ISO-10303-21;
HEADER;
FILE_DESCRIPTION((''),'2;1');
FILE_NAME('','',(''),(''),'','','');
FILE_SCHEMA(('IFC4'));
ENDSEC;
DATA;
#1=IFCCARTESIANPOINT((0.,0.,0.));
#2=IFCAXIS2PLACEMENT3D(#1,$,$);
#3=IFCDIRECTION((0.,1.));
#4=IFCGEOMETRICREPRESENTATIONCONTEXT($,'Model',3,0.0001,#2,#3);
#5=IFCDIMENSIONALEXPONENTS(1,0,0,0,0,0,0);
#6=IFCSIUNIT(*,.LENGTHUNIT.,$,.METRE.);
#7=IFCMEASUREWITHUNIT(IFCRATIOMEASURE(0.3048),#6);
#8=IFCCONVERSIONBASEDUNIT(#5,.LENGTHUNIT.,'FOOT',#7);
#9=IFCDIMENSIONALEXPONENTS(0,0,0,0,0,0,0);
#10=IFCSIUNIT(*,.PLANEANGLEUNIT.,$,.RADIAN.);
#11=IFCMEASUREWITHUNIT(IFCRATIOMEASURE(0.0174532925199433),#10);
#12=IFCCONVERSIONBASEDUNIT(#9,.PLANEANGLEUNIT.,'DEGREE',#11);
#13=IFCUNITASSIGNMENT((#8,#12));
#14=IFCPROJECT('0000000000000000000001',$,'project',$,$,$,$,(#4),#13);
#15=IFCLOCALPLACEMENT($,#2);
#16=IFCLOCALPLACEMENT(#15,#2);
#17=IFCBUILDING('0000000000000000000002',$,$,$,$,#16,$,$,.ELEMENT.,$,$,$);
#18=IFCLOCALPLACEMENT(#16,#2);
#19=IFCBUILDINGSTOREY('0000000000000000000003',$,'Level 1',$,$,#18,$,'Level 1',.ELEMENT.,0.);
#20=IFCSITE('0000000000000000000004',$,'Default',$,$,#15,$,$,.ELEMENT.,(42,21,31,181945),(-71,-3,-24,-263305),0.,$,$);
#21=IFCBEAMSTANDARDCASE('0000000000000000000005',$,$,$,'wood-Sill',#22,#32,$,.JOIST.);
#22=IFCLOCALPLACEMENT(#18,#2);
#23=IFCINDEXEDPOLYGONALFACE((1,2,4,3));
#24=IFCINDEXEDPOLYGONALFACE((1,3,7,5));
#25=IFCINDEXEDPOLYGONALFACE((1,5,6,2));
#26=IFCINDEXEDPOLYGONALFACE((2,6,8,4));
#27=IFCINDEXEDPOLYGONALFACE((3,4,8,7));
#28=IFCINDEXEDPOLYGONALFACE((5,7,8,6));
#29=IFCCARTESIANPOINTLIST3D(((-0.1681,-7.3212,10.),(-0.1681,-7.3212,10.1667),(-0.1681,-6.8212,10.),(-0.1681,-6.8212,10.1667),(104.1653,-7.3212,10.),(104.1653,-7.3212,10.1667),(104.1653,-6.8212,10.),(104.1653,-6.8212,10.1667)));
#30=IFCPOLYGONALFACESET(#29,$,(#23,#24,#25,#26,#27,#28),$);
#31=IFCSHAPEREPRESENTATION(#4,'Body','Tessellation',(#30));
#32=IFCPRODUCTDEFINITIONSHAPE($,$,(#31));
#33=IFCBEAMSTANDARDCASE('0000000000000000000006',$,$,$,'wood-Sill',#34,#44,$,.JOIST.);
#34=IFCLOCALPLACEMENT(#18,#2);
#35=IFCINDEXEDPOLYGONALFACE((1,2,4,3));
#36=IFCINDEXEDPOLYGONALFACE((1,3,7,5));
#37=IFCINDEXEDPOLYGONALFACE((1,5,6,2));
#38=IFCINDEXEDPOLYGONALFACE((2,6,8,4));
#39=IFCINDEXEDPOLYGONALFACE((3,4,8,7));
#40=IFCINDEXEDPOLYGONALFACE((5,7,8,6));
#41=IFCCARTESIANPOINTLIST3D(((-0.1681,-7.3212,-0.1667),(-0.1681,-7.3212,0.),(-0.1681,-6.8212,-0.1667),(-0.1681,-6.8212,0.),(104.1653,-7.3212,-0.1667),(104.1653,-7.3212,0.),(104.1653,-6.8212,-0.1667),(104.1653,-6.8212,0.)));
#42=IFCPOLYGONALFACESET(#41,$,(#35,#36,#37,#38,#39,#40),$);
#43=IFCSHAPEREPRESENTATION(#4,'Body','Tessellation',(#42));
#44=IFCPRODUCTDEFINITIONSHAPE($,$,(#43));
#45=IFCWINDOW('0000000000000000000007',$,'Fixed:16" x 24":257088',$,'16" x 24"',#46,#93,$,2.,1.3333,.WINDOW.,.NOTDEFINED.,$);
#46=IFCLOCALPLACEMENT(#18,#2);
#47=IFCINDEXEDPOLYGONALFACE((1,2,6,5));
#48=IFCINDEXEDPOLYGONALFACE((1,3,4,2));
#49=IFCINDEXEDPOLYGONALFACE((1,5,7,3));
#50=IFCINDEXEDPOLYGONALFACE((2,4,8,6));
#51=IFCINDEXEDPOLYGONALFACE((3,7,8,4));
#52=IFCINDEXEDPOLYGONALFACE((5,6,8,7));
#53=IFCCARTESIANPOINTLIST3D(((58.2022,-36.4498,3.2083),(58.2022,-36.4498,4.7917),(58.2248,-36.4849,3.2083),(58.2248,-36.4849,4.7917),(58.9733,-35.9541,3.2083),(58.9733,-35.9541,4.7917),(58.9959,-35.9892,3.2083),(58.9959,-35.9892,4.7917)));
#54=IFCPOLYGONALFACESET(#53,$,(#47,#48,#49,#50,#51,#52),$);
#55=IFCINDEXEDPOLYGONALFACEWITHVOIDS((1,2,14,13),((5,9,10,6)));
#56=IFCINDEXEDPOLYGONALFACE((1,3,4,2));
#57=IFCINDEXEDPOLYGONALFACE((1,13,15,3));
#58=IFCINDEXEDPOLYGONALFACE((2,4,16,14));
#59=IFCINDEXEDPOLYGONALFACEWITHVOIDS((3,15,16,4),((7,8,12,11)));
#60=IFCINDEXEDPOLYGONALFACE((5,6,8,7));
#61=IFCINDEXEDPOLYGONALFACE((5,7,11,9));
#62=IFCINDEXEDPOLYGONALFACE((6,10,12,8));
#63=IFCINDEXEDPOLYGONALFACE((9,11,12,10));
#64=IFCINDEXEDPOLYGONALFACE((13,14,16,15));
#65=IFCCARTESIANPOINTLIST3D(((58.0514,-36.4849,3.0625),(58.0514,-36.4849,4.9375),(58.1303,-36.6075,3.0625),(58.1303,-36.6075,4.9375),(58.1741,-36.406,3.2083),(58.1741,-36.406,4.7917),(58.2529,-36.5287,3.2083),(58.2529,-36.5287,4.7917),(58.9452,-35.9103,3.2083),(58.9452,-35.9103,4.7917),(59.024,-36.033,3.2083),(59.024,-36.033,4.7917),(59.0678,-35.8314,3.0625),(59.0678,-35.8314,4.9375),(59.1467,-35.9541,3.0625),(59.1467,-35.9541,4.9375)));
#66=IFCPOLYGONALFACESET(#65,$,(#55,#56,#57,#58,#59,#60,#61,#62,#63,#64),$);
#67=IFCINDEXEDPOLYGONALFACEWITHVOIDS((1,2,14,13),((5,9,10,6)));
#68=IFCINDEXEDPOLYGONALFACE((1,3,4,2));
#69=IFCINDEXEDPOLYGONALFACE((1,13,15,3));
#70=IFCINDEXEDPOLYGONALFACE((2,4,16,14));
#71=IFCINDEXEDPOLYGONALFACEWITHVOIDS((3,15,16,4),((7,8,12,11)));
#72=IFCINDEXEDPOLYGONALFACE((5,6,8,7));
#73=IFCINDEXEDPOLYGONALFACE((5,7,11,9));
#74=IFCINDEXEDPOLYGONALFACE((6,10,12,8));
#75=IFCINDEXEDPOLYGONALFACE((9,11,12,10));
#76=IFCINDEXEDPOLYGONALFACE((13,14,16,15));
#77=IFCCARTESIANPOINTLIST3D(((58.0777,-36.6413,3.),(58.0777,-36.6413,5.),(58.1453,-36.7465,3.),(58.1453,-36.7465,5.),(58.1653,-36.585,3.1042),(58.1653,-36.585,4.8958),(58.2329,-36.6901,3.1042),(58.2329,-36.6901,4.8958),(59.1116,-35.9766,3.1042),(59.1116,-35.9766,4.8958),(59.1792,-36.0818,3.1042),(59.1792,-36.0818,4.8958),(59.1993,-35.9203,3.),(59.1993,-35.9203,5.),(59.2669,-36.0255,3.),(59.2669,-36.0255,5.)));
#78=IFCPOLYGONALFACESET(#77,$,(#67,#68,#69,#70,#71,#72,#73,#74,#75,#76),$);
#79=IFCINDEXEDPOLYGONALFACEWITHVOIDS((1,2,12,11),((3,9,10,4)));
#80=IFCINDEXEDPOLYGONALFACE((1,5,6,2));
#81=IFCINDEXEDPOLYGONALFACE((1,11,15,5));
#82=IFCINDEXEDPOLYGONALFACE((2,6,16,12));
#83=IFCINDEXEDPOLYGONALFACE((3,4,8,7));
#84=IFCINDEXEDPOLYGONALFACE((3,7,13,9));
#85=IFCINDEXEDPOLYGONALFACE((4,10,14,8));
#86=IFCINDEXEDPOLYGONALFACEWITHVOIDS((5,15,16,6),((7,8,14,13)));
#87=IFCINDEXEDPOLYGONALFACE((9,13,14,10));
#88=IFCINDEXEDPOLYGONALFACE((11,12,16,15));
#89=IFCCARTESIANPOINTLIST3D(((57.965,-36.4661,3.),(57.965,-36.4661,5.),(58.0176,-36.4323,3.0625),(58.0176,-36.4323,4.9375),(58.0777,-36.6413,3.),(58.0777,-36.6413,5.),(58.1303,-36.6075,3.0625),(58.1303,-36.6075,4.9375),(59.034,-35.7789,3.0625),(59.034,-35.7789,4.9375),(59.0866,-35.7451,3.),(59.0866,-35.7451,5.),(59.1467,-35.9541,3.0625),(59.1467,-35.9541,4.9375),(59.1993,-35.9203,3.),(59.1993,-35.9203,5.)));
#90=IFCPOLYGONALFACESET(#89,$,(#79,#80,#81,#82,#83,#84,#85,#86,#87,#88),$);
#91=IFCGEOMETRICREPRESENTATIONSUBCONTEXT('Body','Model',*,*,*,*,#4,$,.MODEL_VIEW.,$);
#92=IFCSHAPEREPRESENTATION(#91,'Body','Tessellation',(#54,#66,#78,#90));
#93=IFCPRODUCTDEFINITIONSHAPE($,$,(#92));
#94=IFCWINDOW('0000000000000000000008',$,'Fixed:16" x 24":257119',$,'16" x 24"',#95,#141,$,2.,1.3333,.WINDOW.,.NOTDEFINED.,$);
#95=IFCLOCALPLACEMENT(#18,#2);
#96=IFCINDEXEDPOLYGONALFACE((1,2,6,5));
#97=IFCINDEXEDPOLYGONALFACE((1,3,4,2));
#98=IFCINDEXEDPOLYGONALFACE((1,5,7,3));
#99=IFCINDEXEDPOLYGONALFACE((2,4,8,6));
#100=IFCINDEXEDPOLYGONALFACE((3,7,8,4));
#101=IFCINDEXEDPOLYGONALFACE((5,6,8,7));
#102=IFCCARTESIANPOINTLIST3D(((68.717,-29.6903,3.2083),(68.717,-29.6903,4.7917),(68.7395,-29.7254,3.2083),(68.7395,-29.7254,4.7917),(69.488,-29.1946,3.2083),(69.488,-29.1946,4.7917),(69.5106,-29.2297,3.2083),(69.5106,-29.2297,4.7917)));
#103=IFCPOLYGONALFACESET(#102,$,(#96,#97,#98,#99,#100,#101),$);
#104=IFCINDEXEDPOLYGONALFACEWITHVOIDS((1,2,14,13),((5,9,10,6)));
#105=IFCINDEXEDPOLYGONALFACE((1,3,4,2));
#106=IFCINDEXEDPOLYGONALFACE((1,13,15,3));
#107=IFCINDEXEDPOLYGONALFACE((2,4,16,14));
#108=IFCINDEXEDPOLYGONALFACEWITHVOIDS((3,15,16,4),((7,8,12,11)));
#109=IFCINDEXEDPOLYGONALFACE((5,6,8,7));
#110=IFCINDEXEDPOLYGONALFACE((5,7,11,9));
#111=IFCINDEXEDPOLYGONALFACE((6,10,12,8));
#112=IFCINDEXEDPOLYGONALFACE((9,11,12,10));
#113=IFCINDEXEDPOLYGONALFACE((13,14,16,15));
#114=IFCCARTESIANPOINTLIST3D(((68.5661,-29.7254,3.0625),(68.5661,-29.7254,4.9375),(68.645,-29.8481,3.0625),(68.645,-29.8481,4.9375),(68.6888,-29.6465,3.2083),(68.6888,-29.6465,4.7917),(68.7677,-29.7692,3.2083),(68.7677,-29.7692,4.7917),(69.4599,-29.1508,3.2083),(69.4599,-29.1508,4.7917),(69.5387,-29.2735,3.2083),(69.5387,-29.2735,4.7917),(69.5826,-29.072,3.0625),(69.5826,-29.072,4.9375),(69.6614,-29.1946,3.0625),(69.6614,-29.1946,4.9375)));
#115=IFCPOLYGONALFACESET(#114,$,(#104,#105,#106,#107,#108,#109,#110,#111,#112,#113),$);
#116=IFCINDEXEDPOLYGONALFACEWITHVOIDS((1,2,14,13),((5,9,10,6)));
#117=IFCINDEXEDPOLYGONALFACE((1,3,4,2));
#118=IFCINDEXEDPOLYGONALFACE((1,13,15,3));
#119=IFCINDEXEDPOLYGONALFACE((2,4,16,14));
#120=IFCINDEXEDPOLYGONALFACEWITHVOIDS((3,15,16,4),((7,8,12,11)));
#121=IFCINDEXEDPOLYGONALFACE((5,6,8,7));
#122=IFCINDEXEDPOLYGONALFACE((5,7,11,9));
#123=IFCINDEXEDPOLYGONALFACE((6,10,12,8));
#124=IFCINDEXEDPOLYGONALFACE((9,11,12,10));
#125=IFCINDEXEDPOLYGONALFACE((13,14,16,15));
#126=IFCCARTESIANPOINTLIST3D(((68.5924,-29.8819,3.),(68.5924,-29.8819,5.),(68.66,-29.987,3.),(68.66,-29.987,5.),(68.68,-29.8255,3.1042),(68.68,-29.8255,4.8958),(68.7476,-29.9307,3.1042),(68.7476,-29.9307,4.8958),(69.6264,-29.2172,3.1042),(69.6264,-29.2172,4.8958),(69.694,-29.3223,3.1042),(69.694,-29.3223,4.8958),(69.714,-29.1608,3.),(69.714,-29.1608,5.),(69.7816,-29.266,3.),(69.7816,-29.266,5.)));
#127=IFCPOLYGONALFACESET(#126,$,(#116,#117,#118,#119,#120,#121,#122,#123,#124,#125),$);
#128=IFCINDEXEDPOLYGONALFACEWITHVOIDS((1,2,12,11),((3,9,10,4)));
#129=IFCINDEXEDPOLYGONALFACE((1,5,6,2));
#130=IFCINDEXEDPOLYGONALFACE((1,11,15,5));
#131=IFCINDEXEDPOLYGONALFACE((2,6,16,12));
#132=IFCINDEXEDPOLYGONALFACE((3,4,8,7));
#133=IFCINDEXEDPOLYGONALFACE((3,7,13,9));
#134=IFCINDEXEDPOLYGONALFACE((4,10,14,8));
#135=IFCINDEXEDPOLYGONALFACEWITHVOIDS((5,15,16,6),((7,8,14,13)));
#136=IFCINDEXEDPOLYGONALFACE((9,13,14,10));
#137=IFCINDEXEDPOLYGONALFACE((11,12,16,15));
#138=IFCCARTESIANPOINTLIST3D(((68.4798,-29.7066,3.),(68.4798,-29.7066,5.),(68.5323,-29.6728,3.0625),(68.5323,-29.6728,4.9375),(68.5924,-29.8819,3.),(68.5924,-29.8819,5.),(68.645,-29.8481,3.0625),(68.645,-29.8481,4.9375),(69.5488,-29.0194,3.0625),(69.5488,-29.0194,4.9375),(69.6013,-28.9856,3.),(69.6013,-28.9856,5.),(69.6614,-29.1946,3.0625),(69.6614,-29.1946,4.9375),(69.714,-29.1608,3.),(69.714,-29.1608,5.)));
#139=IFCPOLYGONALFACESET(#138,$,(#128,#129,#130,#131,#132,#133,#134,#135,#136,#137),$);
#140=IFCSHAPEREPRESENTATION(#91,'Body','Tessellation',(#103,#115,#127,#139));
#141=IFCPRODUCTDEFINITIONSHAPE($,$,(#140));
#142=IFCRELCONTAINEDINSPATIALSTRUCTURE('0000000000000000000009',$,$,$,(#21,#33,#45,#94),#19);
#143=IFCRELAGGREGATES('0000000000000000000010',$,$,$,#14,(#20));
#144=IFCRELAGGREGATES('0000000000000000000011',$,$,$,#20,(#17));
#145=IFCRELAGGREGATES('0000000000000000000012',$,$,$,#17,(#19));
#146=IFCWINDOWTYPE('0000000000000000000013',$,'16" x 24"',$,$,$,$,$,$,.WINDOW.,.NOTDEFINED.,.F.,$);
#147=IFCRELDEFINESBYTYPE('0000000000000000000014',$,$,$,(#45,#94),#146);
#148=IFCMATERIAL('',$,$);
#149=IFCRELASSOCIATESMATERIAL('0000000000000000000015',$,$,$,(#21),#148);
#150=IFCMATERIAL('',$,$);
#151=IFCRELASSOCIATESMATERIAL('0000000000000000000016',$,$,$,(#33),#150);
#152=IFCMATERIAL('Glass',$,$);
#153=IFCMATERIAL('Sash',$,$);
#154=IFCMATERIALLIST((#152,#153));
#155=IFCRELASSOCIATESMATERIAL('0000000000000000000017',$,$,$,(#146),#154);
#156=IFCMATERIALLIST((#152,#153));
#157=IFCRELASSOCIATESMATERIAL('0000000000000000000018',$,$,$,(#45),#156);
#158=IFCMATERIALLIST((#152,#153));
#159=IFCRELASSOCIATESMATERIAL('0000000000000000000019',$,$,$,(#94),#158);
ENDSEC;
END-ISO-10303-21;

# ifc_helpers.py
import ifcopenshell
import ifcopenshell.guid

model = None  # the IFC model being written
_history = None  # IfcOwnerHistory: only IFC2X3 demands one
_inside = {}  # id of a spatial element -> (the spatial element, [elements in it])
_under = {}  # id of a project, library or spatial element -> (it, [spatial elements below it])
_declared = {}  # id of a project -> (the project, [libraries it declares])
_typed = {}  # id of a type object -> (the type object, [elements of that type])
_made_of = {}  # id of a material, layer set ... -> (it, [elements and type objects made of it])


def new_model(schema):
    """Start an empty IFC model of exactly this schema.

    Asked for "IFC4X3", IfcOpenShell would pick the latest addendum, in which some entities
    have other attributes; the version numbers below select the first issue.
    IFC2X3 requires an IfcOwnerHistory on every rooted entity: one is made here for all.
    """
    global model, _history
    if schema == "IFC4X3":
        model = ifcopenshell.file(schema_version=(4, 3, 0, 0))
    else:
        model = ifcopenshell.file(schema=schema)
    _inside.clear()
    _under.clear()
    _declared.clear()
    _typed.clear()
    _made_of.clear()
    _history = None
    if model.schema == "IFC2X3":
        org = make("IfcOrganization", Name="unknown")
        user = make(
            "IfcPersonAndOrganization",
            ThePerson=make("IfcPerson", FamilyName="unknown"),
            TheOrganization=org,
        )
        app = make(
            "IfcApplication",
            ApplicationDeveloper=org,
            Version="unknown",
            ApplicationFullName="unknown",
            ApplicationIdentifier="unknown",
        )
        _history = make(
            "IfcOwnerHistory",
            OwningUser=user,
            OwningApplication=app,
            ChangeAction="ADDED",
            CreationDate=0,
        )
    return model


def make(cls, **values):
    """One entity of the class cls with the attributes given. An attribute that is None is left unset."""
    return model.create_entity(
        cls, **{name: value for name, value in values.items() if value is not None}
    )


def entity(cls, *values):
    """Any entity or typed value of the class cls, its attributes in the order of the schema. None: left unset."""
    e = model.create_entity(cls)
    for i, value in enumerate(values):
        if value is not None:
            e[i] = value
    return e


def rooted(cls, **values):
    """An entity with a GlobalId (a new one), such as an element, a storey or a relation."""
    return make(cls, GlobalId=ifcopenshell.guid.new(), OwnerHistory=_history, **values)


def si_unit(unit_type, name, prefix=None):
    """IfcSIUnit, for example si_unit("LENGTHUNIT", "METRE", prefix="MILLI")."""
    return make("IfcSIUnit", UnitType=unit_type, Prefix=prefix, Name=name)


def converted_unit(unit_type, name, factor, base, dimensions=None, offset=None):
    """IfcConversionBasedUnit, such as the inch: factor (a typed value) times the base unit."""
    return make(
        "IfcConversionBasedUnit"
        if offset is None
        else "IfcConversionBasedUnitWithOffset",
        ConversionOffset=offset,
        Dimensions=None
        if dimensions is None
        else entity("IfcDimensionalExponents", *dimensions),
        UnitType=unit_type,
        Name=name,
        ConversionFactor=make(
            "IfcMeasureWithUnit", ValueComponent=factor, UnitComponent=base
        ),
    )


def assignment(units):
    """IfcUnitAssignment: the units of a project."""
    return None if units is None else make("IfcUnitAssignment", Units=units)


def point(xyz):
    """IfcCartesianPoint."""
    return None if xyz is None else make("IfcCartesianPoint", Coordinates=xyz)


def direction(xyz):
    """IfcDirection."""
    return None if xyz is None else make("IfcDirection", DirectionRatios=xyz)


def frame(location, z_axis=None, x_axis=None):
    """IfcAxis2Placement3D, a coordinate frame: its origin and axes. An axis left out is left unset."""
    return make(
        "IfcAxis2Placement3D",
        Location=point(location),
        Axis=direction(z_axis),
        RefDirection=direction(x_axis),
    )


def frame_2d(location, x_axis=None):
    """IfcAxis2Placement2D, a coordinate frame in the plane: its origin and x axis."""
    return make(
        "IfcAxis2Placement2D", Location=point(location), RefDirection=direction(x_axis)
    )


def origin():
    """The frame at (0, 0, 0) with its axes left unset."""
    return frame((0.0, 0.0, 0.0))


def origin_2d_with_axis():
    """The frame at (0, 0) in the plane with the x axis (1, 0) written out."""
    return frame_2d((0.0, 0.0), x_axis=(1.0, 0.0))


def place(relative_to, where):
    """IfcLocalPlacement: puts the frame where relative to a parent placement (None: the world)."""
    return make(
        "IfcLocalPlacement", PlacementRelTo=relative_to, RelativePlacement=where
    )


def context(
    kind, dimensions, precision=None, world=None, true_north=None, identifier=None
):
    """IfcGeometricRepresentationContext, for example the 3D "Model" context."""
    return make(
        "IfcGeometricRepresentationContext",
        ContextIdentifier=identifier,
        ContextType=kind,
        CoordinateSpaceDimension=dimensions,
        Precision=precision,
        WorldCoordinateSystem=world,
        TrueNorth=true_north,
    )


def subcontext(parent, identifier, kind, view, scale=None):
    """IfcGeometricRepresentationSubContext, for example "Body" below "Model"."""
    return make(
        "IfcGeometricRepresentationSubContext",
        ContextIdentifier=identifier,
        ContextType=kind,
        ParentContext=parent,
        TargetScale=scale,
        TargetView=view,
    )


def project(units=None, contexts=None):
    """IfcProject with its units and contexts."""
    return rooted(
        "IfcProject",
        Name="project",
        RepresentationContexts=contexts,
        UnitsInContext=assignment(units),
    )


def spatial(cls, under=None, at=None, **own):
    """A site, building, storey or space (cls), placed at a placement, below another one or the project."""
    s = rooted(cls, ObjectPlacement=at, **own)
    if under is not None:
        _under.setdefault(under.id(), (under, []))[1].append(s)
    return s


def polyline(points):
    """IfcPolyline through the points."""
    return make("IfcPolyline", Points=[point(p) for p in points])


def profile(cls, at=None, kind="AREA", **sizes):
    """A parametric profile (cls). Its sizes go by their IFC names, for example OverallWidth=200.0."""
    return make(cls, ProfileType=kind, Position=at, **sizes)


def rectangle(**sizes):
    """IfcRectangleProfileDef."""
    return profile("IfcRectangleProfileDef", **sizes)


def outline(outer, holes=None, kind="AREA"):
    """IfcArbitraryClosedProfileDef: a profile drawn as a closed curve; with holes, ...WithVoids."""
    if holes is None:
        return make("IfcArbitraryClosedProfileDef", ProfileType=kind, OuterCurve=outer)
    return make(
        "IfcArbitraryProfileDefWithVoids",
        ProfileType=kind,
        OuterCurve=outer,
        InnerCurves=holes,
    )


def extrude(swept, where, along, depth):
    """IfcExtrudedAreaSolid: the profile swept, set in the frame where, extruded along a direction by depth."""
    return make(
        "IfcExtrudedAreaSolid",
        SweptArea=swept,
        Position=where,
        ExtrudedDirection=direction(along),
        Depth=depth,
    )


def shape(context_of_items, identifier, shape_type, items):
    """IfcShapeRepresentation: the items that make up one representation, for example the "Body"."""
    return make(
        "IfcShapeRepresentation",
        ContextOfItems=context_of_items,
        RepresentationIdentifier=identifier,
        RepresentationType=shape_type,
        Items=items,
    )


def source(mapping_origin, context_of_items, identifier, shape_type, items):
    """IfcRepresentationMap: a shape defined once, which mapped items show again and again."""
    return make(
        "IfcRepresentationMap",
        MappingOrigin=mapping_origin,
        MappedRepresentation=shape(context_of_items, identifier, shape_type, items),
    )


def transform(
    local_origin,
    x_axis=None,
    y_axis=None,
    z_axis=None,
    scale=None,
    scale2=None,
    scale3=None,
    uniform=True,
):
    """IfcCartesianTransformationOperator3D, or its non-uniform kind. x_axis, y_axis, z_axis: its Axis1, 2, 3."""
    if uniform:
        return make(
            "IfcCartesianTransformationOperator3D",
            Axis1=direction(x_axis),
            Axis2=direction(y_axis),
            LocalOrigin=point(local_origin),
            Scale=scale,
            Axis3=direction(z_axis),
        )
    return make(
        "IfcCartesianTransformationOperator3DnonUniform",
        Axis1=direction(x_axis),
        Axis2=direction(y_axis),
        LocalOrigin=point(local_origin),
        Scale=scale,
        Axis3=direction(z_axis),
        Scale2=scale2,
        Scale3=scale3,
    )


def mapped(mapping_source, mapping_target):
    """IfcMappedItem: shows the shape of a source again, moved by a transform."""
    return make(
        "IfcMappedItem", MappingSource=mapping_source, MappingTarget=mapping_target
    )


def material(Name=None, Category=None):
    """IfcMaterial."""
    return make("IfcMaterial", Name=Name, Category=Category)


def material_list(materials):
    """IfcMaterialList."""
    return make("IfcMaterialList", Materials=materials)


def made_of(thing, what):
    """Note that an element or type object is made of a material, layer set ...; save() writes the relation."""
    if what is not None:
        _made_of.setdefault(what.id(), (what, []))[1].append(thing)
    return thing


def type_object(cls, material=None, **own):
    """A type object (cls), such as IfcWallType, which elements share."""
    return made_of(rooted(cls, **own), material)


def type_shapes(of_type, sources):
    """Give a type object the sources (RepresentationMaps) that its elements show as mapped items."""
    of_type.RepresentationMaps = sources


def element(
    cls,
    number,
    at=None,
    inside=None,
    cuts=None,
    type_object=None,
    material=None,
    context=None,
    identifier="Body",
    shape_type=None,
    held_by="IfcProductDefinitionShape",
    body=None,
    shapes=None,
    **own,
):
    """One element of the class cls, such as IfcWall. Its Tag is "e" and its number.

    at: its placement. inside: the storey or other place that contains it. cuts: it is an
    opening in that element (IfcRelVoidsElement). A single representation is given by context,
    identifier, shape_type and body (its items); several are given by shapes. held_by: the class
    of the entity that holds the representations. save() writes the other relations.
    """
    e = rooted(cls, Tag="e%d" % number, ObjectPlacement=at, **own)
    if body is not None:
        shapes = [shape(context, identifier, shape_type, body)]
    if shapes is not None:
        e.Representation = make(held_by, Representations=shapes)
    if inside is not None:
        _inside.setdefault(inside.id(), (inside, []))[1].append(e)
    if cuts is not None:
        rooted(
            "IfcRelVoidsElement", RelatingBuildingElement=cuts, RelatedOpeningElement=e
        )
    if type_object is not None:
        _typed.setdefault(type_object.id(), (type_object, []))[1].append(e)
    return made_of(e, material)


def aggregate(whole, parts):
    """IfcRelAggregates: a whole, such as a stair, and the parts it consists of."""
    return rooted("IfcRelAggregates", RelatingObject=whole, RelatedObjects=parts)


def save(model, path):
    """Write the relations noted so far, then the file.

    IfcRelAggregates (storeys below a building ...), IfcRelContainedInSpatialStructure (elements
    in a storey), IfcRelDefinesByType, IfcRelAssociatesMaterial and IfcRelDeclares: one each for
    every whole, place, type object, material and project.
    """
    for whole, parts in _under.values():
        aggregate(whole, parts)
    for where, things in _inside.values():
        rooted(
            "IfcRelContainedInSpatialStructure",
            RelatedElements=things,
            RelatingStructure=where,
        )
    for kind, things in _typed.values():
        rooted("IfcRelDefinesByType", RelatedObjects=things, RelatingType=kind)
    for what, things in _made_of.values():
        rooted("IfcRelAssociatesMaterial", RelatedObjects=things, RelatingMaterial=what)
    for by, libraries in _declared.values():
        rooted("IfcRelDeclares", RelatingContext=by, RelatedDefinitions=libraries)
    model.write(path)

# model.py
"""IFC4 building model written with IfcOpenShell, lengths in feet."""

from ifc_helpers import new_model, entity, si_unit, converted_unit, direction, frame, origin, origin_2d_with_axis, place, context, subcontext, project, spatial, polyline, rectangle, outline, extrude, source, transform, mapped, material, material_list, type_object, type_shapes, element, save


model = new_model("IFC4")

# Units and contexts
model_context = context("Model", 3, precision=0.0001, world=origin(), true_north=direction((0.0, 1.0)))
body_context = subcontext(model_context, "Body", "Model", "MODEL_VIEW")
ifc_project = project(units=[converted_unit("LENGTHUNIT", "FOOT", entity("IfcRatioMeasure", 0.3048), si_unit("LENGTHUNIT", "METRE"), dimensions=[1, 0, 0, 0, 0, 0, 0]), converted_unit("PLANEANGLEUNIT", "DEGREE", entity("IfcRatioMeasure", 0.0174532925199433), si_unit("PLANEANGLEUNIT", "RADIAN"), dimensions=[0, 0, 0, 0, 0, 0, 0])], contexts=[model_context])

# Site, building, storey
site_placement = place(None, origin())
site = spatial("IfcSite", under=ifc_project, at=site_placement, Name="Default", CompositionType="ELEMENT", RefLatitude=(42, 21, 31, 181945), RefLongitude=(-71, -3, -24, -263305), RefElevation=0.0)
building_placement = place(site_placement, origin())
building = spatial("IfcBuilding", under=site, at=building_placement, CompositionType="ELEMENT")
storey_placement = place(building_placement, origin())
storey = spatial("IfcBuildingStorey", under=building, at=storey_placement, Name="Level 1", LongName="Level 1", CompositionType="ELEMENT", Elevation=0.0)

# Shared definitions
placement_1 = place(storey_placement, frame((104.1653, -7.0712, 0.0), z_axis=(0.0, 0.0, 1.0), x_axis=(-1.0, 0.0, 0.0)))

# Beams
ifc_material_1 = material(Name="")
beam_1_placement = place(placement_1, frame((52.1667, 0.0, 10.0), z_axis=(0.0, 0.0, 1.0), x_axis=(-1.0, 0.0, 0.0)))
element("IfcBeamStandardCase", 1, at=beam_1_placement, inside=storey, material=ifc_material_1, ObjectType="wood-Sill", PredefinedType="JOIST", context=model_context, shape_type="SweptSolid", body=[
    extrude(rectangle(XDim=104.3334, YDim=0.5), origin(), (0.0, 0.0, 1.0), 0.1667),
])
ifc_material_2 = material(Name="")
beam_2_placement = place(placement_1, frame((52.1667, 0.0, -0.1667), z_axis=(0.0, 0.0, 1.0), x_axis=(-1.0, 0.0, 0.0)))
element("IfcBeamStandardCase", 2, at=beam_2_placement, inside=storey, material=ifc_material_2, ObjectType="wood-Sill", PredefinedType="JOIST", context=model_context, shape_type="SweptSolid", body=[
    extrude(rectangle(XDim=104.3334, YDim=0.5), origin(), (0.0, 0.0, 1.0), 0.1667),
])

# Windows
ifc_material_3 = material(Name="Glass")
ifc_material_4 = material(Name="Sash")
ifc_material_list_1 = material_list([ifc_material_3, ifc_material_4])
ifc_material_list_2 = material_list([ifc_material_3, ifc_material_4])
window_type = type_object("IfcWindowType", Name="16\" x 24\"", ParameterTakesPrecedence=False, PartitioningType="NOTDEFINED", PredefinedType="WINDOW", material=ifc_material_list_2)
shared_shape = source(origin(), body_context, "Body", "SweptSolid", [
    extrude(rectangle(XDim=0.0417, YDim=0.9167, at=origin_2d_with_axis()), frame((0.6667, 0.1979, 0.2083), z_axis=(0.0, 0.0, 1.0), x_axis=(0.0, 1.0, 0.0)), (0.0, 0.0, 1.0), 1.5833),
    extrude(outline(polyline([(-0.6042, -0.9375), (0.6042, -0.9375), (0.6042, 0.9375), (-0.6042, 0.9375), (-0.6042, -0.9375)]), holes=[polyline([(-0.4583, -0.7917), (-0.4583, 0.7917), (0.4583, 0.7917), (0.4583, -0.7917), (-0.4583, -0.7917)])]), frame((0.6667, 0.125, 1.0), z_axis=(0.0, 1.0, 0.0), x_axis=(1.0, 0.0, 0.0)), (0.0, 0.0, 1.0), 0.1458),
    extrude(outline(polyline([(-0.6667, -1.0), (0.6667, -1.0), (0.6667, 1.0), (-0.6667, 1.0), (-0.6667, -1.0)]), holes=[polyline([(-0.5625, -0.8958), (-0.5625, 0.8958), (0.5625, 0.8958), (0.5625, -0.8958), (-0.5625, -0.8958)])]), frame((0.6667, 0.0, 1.0), z_axis=(0.0, 1.0, 0.0), x_axis=(1.0, 0.0, 0.0)), (0.0, 0.0, 1.0), 0.125),
    extrude(outline(polyline([(-1.0, -0.6667), (1.0, -0.6667), (1.0, 0.6667), (-1.0, 0.6667), (-1.0, -0.6667)]), holes=[polyline([(-0.9375, -0.6042), (-0.9375, 0.6042), (0.9375, 0.6042), (0.9375, -0.6042), (-0.9375, -0.6042)])]), frame((0.6667, 0.125, 1.0), z_axis=(0.0, 1.0, 0.0), x_axis=(0.0, 0.0, -1.0)), (0.0, 0.0, 1.0), 0.2083),
])
type_shapes(window_type, [shared_shape])
placement_2 = place(storey_placement, frame((103.9574, -7.0977, 0.0), z_axis=(0.0, 0.0, 1.0), x_axis=(-0.841178, -0.540758, 0.0)))
placement_3 = place(placement_2, frame((54.569, 0.1667, 3.0)))
window_1_placement = place(placement_3, frame((0.0, 0.0, 0.0), z_axis=(0.0, 0.0, 1.0), x_axis=(-1.0, 0.0, 0.0)))
element("IfcWindow", 3, at=window_1_placement, inside=storey, type_object=window_type, material=ifc_material_list_1, Name="Fixed:16\" x 24\":257088", ObjectType="16\" x 24\"", OverallHeight=2.0, OverallWidth=1.3333, PartitioningType="NOTDEFINED", PredefinedType="WINDOW", context=body_context, shape_type="MappedRepresentation", body=[
    mapped(shared_shape, transform((0.0, 0.0, 0.0), scale=1.0)),
])
ifc_material_list_3 = material_list([ifc_material_3, ifc_material_4])
placement_4 = place(placement_2, frame((42.069, 0.1667, 3.0)))
window_2_placement = place(placement_4, frame((0.0, 0.0, 0.0), z_axis=(0.0, 0.0, 1.0), x_axis=(-1.0, 0.0, 0.0)))
element("IfcWindow", 4, at=window_2_placement, inside=storey, type_object=window_type, material=ifc_material_list_3, Name="Fixed:16\" x 24\":257119", ObjectType="16\" x 24\"", OverallHeight=2.0, OverallWidth=1.3333, PartitioningType="NOTDEFINED", PredefinedType="WINDOW", context=body_context, shape_type="MappedRepresentation", body=[
    mapped(shared_shape, transform((0.0, 0.0, 0.0), scale=1.0)),
])

save(model, "model.ifc")
